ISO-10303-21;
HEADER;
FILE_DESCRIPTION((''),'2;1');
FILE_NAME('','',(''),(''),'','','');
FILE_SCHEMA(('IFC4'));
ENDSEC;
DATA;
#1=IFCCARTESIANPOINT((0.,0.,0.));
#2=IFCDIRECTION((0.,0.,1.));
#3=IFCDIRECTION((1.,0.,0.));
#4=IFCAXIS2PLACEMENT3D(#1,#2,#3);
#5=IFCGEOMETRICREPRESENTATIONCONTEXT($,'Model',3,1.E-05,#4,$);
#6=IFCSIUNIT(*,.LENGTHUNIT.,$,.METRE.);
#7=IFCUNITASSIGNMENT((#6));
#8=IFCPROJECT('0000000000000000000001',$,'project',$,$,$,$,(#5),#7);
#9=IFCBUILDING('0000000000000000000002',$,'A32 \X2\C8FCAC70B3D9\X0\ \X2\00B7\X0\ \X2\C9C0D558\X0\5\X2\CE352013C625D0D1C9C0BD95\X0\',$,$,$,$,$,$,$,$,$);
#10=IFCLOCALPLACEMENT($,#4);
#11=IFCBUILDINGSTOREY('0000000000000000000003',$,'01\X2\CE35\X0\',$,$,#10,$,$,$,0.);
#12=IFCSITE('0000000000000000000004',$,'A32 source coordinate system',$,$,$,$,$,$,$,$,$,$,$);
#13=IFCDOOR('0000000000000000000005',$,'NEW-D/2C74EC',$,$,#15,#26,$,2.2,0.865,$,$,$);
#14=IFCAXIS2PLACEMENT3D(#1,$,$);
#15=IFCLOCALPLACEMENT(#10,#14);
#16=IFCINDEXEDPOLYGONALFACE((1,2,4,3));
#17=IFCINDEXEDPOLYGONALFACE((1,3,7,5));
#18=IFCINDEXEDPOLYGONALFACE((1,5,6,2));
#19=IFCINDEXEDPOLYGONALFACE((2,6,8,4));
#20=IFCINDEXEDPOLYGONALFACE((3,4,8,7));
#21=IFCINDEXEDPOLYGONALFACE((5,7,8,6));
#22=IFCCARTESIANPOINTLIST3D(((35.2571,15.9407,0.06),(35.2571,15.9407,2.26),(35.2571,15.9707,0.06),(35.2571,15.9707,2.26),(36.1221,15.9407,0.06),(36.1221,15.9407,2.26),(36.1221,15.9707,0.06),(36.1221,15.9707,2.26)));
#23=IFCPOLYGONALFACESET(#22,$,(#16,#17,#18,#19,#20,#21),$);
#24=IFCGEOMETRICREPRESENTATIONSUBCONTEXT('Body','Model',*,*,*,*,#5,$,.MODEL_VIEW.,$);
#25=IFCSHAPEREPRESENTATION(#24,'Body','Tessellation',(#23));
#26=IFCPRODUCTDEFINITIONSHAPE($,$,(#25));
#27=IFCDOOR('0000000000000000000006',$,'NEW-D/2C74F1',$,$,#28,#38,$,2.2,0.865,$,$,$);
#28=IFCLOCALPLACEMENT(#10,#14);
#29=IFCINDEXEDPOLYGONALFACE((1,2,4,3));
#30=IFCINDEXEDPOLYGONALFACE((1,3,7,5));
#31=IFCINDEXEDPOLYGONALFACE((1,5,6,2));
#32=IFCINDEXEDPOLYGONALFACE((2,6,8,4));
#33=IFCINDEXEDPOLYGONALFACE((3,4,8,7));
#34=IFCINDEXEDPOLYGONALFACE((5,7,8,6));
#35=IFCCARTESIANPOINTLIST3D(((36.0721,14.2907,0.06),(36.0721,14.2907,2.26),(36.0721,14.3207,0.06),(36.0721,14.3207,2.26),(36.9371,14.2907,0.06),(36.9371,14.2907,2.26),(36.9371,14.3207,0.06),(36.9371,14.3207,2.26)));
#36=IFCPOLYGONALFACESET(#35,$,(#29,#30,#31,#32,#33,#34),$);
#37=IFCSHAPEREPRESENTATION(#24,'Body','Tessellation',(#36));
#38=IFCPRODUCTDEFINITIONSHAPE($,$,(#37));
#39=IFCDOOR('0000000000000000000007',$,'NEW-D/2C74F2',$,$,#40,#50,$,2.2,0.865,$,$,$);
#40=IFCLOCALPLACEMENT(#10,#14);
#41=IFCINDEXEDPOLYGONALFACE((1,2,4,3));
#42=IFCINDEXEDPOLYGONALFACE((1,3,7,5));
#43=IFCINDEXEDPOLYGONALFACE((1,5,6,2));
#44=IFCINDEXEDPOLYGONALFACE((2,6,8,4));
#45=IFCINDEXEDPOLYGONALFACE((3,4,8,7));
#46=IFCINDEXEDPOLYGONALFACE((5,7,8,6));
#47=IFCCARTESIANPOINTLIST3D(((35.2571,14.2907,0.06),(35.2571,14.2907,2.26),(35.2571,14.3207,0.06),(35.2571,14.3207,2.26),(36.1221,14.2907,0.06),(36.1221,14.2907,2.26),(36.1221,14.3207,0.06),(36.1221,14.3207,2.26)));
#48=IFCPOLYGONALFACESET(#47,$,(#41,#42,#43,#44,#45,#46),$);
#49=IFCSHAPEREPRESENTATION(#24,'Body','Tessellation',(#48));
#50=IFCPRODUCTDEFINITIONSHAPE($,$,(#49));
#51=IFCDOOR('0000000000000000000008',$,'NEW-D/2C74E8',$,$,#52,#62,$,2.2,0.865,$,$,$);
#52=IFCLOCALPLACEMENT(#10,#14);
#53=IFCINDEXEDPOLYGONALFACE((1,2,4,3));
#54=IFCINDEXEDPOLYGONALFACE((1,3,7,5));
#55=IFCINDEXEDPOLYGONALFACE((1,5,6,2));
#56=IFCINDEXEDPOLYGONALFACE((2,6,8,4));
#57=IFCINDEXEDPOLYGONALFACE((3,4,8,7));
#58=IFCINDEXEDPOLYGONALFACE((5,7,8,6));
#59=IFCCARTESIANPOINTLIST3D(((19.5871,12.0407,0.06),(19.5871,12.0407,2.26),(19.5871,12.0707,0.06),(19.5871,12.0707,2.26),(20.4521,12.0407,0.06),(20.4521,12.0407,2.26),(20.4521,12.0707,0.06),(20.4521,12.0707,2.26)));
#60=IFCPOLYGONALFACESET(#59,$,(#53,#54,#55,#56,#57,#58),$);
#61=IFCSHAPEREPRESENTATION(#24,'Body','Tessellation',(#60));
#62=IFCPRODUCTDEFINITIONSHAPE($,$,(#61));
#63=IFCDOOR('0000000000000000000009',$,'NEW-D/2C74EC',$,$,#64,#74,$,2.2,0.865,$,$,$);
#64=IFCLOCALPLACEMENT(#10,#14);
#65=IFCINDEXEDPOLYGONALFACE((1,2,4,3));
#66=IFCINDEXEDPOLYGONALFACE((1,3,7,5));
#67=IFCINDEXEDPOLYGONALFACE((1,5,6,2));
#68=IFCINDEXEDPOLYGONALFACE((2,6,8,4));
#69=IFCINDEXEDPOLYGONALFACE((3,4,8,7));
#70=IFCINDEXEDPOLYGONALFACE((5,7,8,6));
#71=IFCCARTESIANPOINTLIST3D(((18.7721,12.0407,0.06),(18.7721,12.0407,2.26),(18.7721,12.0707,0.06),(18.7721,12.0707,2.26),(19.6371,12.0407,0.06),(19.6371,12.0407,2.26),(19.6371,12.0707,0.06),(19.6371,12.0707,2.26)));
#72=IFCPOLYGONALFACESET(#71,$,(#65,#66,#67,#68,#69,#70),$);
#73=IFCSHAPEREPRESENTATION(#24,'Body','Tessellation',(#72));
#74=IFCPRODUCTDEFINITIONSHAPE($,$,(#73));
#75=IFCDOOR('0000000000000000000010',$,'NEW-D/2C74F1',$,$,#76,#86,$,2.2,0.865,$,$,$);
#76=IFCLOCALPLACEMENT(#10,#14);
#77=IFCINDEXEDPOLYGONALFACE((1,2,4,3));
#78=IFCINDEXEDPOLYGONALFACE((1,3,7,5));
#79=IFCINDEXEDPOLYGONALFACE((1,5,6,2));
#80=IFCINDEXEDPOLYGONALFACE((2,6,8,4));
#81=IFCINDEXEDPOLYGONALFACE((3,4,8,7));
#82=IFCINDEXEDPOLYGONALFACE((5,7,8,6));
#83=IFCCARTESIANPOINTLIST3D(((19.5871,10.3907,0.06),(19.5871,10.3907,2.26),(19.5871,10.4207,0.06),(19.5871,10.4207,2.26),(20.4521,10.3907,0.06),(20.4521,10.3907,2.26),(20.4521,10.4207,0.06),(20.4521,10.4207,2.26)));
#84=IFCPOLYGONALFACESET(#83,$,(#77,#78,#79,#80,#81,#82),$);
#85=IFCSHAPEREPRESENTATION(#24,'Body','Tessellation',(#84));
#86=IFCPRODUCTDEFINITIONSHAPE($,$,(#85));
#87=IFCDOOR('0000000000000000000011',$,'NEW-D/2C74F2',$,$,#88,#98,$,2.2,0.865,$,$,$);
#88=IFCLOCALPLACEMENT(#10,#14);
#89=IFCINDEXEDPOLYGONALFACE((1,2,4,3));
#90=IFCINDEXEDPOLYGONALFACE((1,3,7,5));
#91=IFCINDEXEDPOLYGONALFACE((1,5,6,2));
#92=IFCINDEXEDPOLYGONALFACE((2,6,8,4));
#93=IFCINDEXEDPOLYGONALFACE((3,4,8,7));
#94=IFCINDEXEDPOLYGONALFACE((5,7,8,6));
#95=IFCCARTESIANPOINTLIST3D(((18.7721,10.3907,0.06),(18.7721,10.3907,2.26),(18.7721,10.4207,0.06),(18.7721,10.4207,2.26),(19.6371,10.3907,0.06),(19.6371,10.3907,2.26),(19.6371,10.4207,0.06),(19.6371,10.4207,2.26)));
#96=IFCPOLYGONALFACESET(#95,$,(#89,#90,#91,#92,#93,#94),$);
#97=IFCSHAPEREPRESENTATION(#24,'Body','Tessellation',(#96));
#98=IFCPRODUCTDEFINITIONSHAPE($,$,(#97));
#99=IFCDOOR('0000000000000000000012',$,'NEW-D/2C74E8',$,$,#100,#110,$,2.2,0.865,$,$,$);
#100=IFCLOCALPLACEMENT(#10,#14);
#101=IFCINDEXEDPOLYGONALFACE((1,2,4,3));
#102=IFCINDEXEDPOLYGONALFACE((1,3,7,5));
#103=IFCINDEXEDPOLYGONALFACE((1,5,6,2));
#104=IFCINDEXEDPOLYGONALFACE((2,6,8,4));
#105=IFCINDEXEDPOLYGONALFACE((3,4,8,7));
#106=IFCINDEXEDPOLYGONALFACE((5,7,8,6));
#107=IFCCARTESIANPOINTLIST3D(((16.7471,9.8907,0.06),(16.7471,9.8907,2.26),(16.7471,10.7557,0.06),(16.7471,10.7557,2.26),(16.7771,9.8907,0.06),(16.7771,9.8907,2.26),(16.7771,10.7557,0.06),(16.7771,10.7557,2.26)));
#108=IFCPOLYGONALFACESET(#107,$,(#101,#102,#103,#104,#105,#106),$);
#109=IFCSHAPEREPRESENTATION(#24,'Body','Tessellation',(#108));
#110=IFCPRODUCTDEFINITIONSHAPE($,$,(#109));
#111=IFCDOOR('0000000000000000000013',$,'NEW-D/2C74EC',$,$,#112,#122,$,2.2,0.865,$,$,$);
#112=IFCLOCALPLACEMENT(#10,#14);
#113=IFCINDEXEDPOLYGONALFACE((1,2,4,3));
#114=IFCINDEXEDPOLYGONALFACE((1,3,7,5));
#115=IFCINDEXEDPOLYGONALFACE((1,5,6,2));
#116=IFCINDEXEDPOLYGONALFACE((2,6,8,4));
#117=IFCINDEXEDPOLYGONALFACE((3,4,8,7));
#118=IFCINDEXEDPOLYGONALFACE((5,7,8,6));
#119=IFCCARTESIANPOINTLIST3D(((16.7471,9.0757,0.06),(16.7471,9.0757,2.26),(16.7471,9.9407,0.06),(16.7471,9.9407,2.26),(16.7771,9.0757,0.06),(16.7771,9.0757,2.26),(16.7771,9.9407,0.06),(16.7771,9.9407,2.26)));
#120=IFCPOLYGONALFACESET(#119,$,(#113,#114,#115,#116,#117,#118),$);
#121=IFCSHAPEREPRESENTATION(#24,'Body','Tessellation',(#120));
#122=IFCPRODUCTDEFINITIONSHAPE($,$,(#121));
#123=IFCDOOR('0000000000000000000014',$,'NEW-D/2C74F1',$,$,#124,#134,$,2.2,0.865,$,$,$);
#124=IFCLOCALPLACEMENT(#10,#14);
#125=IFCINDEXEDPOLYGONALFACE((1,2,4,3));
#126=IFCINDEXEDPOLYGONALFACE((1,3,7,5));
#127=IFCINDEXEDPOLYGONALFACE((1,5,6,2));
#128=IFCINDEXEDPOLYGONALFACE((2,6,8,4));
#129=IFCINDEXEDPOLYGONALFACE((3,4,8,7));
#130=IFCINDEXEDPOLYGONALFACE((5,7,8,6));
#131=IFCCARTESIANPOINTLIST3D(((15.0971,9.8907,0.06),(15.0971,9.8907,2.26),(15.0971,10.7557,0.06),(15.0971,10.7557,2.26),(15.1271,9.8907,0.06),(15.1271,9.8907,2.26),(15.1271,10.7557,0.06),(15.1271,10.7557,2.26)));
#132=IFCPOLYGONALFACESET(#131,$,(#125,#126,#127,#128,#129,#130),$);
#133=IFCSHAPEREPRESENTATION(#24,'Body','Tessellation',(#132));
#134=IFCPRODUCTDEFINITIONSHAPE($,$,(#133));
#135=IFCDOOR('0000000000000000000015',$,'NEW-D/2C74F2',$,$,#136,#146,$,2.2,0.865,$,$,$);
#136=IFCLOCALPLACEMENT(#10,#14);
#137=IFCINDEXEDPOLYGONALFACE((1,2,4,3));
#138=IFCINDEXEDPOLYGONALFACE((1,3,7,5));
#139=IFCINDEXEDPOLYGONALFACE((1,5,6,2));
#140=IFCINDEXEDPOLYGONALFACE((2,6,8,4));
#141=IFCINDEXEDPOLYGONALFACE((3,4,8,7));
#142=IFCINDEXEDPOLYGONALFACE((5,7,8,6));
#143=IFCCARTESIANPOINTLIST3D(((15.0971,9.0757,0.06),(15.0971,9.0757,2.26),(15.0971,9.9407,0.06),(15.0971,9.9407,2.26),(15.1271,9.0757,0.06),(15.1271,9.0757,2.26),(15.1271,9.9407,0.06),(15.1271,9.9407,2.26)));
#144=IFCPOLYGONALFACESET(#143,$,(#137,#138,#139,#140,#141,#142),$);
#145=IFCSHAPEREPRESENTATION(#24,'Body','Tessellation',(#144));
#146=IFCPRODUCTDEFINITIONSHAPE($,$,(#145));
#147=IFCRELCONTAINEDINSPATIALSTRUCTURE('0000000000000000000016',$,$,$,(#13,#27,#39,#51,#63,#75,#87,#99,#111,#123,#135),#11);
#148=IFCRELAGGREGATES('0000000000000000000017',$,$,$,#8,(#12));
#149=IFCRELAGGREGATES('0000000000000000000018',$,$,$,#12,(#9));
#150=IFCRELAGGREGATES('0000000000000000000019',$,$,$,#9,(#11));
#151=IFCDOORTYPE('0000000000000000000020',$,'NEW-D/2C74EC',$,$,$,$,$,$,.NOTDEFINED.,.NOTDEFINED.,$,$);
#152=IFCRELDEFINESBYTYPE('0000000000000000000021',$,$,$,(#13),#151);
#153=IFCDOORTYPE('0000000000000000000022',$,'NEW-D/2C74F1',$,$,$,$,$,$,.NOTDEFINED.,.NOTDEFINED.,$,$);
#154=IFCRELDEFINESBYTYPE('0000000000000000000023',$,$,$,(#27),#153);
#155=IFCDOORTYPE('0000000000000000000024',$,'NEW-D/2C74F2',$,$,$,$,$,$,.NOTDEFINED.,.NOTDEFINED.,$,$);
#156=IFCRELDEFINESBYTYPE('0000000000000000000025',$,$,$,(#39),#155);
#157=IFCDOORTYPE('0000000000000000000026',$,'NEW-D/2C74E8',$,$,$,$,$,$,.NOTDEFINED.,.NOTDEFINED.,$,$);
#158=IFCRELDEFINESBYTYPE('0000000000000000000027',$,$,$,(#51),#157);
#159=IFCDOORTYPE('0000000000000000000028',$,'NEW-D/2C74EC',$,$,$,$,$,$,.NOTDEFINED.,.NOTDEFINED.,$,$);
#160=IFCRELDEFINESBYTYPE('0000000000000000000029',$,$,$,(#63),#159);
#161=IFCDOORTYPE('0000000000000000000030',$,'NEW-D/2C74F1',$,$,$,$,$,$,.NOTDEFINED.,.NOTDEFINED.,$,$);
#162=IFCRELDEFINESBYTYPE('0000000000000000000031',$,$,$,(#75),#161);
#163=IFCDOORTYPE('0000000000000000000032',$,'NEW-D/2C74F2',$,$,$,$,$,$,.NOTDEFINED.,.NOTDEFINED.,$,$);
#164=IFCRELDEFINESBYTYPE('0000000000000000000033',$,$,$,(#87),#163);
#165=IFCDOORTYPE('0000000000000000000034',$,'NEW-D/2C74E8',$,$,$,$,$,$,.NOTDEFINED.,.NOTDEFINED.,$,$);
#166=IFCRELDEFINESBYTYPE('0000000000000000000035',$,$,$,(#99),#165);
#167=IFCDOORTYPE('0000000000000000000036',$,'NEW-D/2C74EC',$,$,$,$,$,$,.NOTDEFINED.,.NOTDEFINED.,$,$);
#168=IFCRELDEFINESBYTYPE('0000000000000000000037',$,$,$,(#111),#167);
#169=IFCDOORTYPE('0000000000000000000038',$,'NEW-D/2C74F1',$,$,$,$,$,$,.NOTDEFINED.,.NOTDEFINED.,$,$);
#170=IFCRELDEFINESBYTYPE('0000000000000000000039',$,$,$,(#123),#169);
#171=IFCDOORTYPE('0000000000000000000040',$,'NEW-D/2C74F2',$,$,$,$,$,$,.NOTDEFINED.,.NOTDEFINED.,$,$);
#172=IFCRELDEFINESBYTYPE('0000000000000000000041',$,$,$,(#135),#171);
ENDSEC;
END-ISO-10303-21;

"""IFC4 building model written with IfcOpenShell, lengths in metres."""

from ifc_helpers import new_model, si_unit, frame, origin, origin_with_axes, place, context, subcontext, project, spatial, polyline, outline, extrude, source, transform, mapped, type_object, type_shapes, element, save


model = new_model("IFC4")

# Units and contexts
model_context = context("Model", 3, precision=1e-05, world=origin_with_axes())
body_context = subcontext(model_context, "Body", "Model", "MODEL_VIEW")
ifc_project = project(units=[si_unit("LENGTHUNIT", "METRE")], contexts=[model_context])

# Site, building, storey
site = spatial("IfcSite", under=ifc_project, Name="A32 source coordinate system")
building = spatial("IfcBuilding", under=site, Name="A32 주거동 · 지하5층–옥탑지붕")
storey_placement = place(None, origin_with_axes())
storey = spatial("IfcBuildingStorey", under=building, at=storey_placement, Name="01층", Elevation=0.0)

# Doors
door_type_1 = type_object("IfcDoorType", Name="NEW-D/2C74EC", OperationType="NOTDEFINED", PredefinedType="NOTDEFINED")
shared_shape_1 = source(origin(), body_context, "Body", "SweptSolid", [
    extrude(outline(polyline([(36.1221, 15.9407), (35.2571, 15.9407), (35.2571, 15.9707), (36.1221, 15.9707), (36.1221, 15.9407)])), frame((0.0, 0.0, 0.06)), (0.0, 0.0, 1.0), 2.2),
])
type_shapes(door_type_1, [shared_shape_1])
door_1_placement = place(storey_placement, origin_with_axes())
element("IfcDoor", 1, at=door_1_placement, inside=storey, type_object=door_type_1, Name="NEW-D/2C74EC", OverallHeight=2.2, OverallWidth=0.865, context=body_context, shape_type="MappedRepresentation", body=[
    mapped(shared_shape_1, transform((0.0, 0.0, 0.0), scale=1.0)),
])
door_type_2 = type_object("IfcDoorType", Name="NEW-D/2C74F1", OperationType="NOTDEFINED", PredefinedType="NOTDEFINED")
shared_shape_2 = source(origin(), body_context, "Body", "SweptSolid", [
    extrude(outline(polyline([(36.0721, 14.3207), (36.9371, 14.3207), (36.9371, 14.2907), (36.0721, 14.2907), (36.0721, 14.3207)])), frame((0.0, 0.0, 0.06)), (0.0, 0.0, 1.0), 2.2),
])
type_shapes(door_type_2, [shared_shape_2])
door_2_placement = place(storey_placement, origin_with_axes())
element("IfcDoor", 2, at=door_2_placement, inside=storey, type_object=door_type_2, Name="NEW-D/2C74F1", OverallHeight=2.2, OverallWidth=0.865, context=body_context, shape_type="MappedRepresentation", body=[
    mapped(shared_shape_2, transform((0.0, 0.0, 0.0), scale=1.0)),
])
door_type_3 = type_object("IfcDoorType", Name="NEW-D/2C74F2", OperationType="NOTDEFINED", PredefinedType="NOTDEFINED")
shared_shape_3 = source(origin(), body_context, "Body", "SweptSolid", [
    extrude(outline(polyline([(35.2571, 14.2907), (35.2571, 14.3207), (36.1221, 14.3207), (36.1221, 14.2907), (35.2571, 14.2907)])), frame((0.0, 0.0, 0.06)), (0.0, 0.0, 1.0), 2.2),
])
type_shapes(door_type_3, [shared_shape_3])
door_3_placement = place(storey_placement, origin_with_axes())
element("IfcDoor", 3, at=door_3_placement, inside=storey, type_object=door_type_3, Name="NEW-D/2C74F2", OverallHeight=2.2, OverallWidth=0.865, context=body_context, shape_type="MappedRepresentation", body=[
    mapped(shared_shape_3, transform((0.0, 0.0, 0.0), scale=1.0)),
])
door_type_4 = type_object("IfcDoorType", Name="NEW-D/2C74E8", OperationType="NOTDEFINED", PredefinedType="NOTDEFINED")
shared_shape_4 = source(origin(), body_context, "Body", "SweptSolid", [
    extrude(outline(polyline([(20.4521, 12.0707), (20.4521, 12.0407), (19.5871, 12.0407), (19.5871, 12.0707), (20.4521, 12.0707)])), frame((0.0, 0.0, 0.06)), (0.0, 0.0, 1.0), 2.2),
])
type_shapes(door_type_4, [shared_shape_4])
door_4_placement = place(storey_placement, origin_with_axes())
element("IfcDoor", 4, at=door_4_placement, inside=storey, type_object=door_type_4, Name="NEW-D/2C74E8", OverallHeight=2.2, OverallWidth=0.865, context=body_context, shape_type="MappedRepresentation", body=[
    mapped(shared_shape_4, transform((0.0, 0.0, 0.0), scale=1.0)),
])
door_type_5 = type_object("IfcDoorType", Name="NEW-D/2C74EC", OperationType="NOTDEFINED", PredefinedType="NOTDEFINED")
shared_shape_5 = source(origin(), body_context, "Body", "SweptSolid", [
    extrude(outline(polyline([(19.6371, 12.0407), (18.7721, 12.0407), (18.7721, 12.0707), (19.6371, 12.0707), (19.6371, 12.0407)])), frame((0.0, 0.0, 0.06)), (0.0, 0.0, 1.0), 2.2),
])
type_shapes(door_type_5, [shared_shape_5])
door_5_placement = place(storey_placement, origin_with_axes())
element("IfcDoor", 5, at=door_5_placement, inside=storey, type_object=door_type_5, Name="NEW-D/2C74EC", OverallHeight=2.2, OverallWidth=0.865, context=body_context, shape_type="MappedRepresentation", body=[
    mapped(shared_shape_5, transform((0.0, 0.0, 0.0), scale=1.0)),
])
door_type_6 = type_object("IfcDoorType", Name="NEW-D/2C74F1", OperationType="NOTDEFINED", PredefinedType="NOTDEFINED")
shared_shape_6 = source(origin(), body_context, "Body", "SweptSolid", [
    extrude(outline(polyline([(19.5871, 10.4207), (20.4521, 10.4207), (20.4521, 10.3907), (19.5871, 10.3907), (19.5871, 10.4207)])), frame((0.0, 0.0, 0.06)), (0.0, 0.0, 1.0), 2.2),
])
type_shapes(door_type_6, [shared_shape_6])
door_6_placement = place(storey_placement, origin_with_axes())
element("IfcDoor", 6, at=door_6_placement, inside=storey, type_object=door_type_6, Name="NEW-D/2C74F1", OverallHeight=2.2, OverallWidth=0.865, context=body_context, shape_type="MappedRepresentation", body=[
    mapped(shared_shape_6, transform((0.0, 0.0, 0.0), scale=1.0)),
])
door_type_7 = type_object("IfcDoorType", Name="NEW-D/2C74F2", OperationType="NOTDEFINED", PredefinedType="NOTDEFINED")
shared_shape_7 = source(origin(), body_context, "Body", "SweptSolid", [
    extrude(outline(polyline([(18.7721, 10.3907), (18.7721, 10.4207), (19.6371, 10.4207), (19.6371, 10.3907), (18.7721, 10.3907)])), frame((0.0, 0.0, 0.06)), (0.0, 0.0, 1.0), 2.2),
])
type_shapes(door_type_7, [shared_shape_7])
door_7_placement = place(storey_placement, origin_with_axes())
element("IfcDoor", 7, at=door_7_placement, inside=storey, type_object=door_type_7, Name="NEW-D/2C74F2", OverallHeight=2.2, OverallWidth=0.865, context=body_context, shape_type="MappedRepresentation", body=[
    mapped(shared_shape_7, transform((0.0, 0.0, 0.0), scale=1.0)),
])
door_type_8 = type_object("IfcDoorType", Name="NEW-D/2C74E8", OperationType="NOTDEFINED", PredefinedType="NOTDEFINED")
shared_shape_8 = source(origin(), body_context, "Body", "SweptSolid", [
    extrude(outline(polyline([(16.7471, 9.8907), (16.7471, 10.7557), (16.7771, 10.7557), (16.7771, 9.8907), (16.7471, 9.8907)])), frame((0.0, 0.0, 0.06)), (0.0, 0.0, 1.0), 2.2),
])
type_shapes(door_type_8, [shared_shape_8])
door_8_placement = place(storey_placement, origin_with_axes())
element("IfcDoor", 8, at=door_8_placement, inside=storey, type_object=door_type_8, Name="NEW-D/2C74E8", OverallHeight=2.2, OverallWidth=0.865, context=body_context, shape_type="MappedRepresentation", body=[
    mapped(shared_shape_8, transform((0.0, 0.0, 0.0), scale=1.0)),
])
door_type_9 = type_object("IfcDoorType", Name="NEW-D/2C74EC", OperationType="NOTDEFINED", PredefinedType="NOTDEFINED")
shared_shape_9 = source(origin(), body_context, "Body", "SweptSolid", [
    extrude(outline(polyline([(16.7771, 9.0757), (16.7471, 9.0757), (16.7471, 9.9407), (16.7771, 9.9407), (16.7771, 9.0757)])), frame((0.0, 0.0, 0.06)), (0.0, 0.0, 1.0), 2.2),
])
type_shapes(door_type_9, [shared_shape_9])
door_9_placement = place(storey_placement, origin_with_axes())
element("IfcDoor", 9, at=door_9_placement, inside=storey, type_object=door_type_9, Name="NEW-D/2C74EC", OverallHeight=2.2, OverallWidth=0.865, context=body_context, shape_type="MappedRepresentation", body=[
    mapped(shared_shape_9, transform((0.0, 0.0, 0.0), scale=1.0)),
])
door_type_10 = type_object("IfcDoorType", Name="NEW-D/2C74F1", OperationType="NOTDEFINED", PredefinedType="NOTDEFINED")
shared_shape_10 = source(origin(), body_context, "Body", "SweptSolid", [
    extrude(outline(polyline([(15.0971, 10.7557), (15.1271, 10.7557), (15.1271, 9.8907), (15.0971, 9.8907), (15.0971, 10.7557)])), frame((0.0, 0.0, 0.06)), (0.0, 0.0, 1.0), 2.2),
])
type_shapes(door_type_10, [shared_shape_10])
door_10_placement = place(storey_placement, origin_with_axes())
element("IfcDoor", 10, at=door_10_placement, inside=storey, type_object=door_type_10, Name="NEW-D/2C74F1", OverallHeight=2.2, OverallWidth=0.865, context=body_context, shape_type="MappedRepresentation", body=[
    mapped(shared_shape_10, transform((0.0, 0.0, 0.0), scale=1.0)),
])
door_type_11 = type_object("IfcDoorType", Name="NEW-D/2C74F2", OperationType="NOTDEFINED", PredefinedType="NOTDEFINED")
shared_shape_11 = source(origin(), body_context, "Body", "SweptSolid", [
    extrude(outline(polyline([(15.1271, 9.9407), (15.1271, 9.0757), (15.0971, 9.0757), (15.0971, 9.9407), (15.1271, 9.9407)])), frame((0.0, 0.0, 0.06)), (0.0, 0.0, 1.0), 2.2),
])
type_shapes(door_type_11, [shared_shape_11])
door_11_placement = place(storey_placement, origin_with_axes())
element("IfcDoor", 11, at=door_11_placement, inside=storey, type_object=door_type_11, Name="NEW-D/2C74F2", OverallHeight=2.2, OverallWidth=0.865, context=body_context, shape_type="MappedRepresentation", body=[
    mapped(shared_shape_11, transform((0.0, 0.0, 0.0), scale=1.0)),
])

save(model, "model.ifc")
